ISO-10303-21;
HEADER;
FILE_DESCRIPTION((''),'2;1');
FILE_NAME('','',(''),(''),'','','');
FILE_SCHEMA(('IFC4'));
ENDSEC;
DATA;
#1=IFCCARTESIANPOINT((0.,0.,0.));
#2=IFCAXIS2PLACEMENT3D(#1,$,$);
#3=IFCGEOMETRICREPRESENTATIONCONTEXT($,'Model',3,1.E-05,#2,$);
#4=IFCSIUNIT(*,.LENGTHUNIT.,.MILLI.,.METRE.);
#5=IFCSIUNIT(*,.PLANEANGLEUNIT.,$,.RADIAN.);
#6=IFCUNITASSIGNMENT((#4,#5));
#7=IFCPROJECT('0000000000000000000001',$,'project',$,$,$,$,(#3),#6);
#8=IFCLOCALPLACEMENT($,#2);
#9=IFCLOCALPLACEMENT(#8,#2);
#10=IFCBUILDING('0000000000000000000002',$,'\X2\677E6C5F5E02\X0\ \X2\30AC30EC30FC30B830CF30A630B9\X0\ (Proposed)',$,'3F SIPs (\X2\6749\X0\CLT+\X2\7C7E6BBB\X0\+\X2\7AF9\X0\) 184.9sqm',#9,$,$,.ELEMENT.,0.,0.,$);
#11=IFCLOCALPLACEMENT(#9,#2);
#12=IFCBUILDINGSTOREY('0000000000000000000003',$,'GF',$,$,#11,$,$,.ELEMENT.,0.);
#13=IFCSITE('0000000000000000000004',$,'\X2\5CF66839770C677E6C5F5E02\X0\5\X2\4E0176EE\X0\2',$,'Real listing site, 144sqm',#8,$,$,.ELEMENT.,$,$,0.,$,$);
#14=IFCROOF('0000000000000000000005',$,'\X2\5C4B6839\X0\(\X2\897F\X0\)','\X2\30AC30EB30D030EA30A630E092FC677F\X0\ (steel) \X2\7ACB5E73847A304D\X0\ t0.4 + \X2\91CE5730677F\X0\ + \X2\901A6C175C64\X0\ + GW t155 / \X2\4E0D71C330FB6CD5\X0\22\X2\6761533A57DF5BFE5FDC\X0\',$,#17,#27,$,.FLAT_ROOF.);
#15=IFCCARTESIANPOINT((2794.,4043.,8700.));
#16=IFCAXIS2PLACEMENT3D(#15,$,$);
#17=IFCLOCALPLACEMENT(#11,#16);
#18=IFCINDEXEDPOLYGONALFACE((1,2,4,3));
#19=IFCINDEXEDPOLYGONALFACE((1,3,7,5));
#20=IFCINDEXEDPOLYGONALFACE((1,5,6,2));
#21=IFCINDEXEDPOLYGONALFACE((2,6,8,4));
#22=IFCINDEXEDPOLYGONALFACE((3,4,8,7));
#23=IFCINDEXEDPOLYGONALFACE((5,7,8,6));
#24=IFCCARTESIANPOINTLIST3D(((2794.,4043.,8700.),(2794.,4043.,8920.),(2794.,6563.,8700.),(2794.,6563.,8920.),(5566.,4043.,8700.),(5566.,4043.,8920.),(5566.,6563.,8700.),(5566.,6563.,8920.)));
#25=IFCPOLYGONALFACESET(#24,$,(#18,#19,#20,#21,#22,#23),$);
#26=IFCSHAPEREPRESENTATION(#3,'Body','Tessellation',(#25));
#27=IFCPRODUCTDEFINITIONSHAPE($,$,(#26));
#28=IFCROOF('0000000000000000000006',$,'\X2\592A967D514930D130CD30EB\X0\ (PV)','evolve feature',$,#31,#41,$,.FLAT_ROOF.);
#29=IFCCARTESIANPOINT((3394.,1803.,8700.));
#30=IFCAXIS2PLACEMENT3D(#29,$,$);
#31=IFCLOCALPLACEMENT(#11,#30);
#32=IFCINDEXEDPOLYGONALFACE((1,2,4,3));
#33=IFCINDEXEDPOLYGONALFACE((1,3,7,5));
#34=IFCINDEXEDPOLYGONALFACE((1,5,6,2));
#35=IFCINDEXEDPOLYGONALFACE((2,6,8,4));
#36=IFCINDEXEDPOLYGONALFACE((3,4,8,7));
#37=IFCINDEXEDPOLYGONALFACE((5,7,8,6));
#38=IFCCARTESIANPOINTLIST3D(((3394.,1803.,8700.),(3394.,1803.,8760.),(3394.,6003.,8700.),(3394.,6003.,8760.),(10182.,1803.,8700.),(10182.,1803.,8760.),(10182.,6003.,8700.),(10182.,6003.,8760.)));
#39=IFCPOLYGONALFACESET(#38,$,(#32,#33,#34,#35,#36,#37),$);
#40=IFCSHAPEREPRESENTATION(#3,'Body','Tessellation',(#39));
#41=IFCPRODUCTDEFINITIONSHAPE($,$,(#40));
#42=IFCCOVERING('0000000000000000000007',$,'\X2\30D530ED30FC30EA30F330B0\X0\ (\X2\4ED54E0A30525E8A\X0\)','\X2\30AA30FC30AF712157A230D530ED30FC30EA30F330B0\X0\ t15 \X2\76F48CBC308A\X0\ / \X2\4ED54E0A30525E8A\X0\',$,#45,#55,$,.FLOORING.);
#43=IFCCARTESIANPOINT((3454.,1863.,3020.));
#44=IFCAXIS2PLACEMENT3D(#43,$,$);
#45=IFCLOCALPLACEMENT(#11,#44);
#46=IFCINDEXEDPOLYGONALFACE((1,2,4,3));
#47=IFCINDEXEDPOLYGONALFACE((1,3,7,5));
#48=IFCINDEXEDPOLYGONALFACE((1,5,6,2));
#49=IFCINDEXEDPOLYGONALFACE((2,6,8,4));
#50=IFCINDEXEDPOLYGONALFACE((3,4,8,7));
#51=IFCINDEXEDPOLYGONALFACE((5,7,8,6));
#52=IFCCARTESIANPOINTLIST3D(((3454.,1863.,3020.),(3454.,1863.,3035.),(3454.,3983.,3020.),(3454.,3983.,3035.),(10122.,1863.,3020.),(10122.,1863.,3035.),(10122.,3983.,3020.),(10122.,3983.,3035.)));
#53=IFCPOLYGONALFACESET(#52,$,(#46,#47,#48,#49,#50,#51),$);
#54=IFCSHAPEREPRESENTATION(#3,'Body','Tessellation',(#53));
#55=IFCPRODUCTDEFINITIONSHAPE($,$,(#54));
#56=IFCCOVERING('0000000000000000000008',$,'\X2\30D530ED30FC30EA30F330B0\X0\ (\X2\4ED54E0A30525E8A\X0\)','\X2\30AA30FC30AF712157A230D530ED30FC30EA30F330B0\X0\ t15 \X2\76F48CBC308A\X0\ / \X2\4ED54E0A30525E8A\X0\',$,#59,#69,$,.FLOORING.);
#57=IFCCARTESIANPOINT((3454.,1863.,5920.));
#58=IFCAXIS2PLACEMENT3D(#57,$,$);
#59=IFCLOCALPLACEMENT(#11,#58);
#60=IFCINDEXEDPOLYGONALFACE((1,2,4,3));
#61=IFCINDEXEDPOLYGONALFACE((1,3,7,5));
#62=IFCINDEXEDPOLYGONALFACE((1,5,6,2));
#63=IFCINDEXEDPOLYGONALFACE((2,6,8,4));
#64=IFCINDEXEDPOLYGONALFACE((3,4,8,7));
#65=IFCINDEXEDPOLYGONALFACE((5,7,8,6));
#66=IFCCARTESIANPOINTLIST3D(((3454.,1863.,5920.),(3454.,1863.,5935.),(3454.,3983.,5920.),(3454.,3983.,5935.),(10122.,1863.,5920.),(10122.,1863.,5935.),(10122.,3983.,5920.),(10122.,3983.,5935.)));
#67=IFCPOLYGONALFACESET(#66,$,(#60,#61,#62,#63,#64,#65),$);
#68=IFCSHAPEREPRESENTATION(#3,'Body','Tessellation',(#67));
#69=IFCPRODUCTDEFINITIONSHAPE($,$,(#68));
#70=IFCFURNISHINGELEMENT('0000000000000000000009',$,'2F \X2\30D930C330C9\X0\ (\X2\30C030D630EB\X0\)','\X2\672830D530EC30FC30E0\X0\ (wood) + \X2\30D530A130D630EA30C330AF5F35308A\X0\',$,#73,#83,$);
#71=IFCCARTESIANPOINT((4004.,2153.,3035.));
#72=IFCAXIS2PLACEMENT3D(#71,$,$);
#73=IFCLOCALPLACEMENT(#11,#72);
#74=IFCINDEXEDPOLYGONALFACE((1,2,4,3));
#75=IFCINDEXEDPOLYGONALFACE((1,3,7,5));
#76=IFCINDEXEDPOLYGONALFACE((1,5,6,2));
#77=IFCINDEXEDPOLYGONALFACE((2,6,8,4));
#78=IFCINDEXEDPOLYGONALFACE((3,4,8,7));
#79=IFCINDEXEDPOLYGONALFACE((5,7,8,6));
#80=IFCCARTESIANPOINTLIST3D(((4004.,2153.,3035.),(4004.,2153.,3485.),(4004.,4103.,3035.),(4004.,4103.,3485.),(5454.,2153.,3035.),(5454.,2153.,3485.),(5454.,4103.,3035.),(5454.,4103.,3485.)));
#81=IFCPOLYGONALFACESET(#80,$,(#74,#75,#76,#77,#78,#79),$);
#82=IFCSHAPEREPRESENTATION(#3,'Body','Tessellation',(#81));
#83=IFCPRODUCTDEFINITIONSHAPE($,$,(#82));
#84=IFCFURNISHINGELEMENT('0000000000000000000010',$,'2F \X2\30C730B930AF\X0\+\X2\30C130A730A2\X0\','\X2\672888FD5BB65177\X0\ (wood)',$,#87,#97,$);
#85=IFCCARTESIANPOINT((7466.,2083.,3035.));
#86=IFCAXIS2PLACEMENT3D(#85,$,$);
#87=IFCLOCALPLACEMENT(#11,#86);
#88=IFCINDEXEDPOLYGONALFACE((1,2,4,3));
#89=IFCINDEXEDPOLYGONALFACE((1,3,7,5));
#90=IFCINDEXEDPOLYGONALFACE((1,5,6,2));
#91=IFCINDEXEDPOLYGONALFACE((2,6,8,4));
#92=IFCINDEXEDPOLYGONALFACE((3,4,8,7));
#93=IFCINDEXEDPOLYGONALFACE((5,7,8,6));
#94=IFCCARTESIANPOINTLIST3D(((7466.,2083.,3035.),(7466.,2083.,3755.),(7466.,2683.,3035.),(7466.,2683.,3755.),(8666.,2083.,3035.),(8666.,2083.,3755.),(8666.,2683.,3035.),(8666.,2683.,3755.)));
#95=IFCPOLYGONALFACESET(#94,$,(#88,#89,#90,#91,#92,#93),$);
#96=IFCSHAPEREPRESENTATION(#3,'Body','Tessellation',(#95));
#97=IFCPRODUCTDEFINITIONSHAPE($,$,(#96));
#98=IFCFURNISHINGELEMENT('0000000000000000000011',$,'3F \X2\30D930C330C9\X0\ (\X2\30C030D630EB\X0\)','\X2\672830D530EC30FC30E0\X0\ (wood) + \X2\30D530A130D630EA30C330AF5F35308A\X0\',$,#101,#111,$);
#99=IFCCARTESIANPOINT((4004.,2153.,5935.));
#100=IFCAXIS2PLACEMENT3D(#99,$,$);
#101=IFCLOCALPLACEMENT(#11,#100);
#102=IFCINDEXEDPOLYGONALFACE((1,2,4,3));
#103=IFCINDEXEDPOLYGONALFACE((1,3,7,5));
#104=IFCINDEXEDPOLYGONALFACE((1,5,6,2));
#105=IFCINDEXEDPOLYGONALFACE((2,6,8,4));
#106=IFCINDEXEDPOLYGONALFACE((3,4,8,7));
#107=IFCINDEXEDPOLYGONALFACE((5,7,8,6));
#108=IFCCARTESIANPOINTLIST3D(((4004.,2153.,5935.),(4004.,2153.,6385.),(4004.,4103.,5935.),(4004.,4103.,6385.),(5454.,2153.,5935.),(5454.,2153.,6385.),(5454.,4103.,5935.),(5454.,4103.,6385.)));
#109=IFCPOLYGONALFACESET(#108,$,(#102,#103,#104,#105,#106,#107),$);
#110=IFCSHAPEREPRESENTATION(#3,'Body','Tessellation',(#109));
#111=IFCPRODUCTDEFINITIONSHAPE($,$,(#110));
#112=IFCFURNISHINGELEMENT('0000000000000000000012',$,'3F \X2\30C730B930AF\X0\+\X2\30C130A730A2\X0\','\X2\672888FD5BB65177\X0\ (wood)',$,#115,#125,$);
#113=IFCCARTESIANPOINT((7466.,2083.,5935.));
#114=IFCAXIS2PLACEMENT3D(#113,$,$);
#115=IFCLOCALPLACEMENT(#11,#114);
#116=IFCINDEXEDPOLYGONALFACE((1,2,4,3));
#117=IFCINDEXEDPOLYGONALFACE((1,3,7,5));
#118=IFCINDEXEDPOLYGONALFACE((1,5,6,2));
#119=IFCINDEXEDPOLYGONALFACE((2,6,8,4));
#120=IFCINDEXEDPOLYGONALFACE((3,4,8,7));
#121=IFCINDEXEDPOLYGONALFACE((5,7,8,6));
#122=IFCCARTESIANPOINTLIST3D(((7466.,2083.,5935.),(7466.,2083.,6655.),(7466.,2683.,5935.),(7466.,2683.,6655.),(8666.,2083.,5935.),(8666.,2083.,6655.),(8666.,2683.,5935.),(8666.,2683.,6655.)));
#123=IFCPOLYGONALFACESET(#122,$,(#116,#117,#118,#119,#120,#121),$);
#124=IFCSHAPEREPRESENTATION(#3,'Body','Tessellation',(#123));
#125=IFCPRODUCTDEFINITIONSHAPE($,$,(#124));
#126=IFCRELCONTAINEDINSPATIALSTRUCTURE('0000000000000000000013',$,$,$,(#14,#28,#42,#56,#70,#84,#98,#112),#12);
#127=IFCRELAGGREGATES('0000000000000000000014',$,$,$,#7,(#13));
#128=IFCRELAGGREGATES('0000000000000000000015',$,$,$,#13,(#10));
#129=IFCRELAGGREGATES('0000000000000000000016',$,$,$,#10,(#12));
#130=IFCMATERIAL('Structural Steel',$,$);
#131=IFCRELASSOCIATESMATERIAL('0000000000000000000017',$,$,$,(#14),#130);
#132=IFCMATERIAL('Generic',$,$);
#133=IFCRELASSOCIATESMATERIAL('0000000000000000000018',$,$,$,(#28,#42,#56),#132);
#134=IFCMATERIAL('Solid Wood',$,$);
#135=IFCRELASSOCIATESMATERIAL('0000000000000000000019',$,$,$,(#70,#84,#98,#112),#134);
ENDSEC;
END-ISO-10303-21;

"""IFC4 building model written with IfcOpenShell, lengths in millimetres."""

from ifc_helpers import new_model, si_unit, frame, frame_2d, origin, place, context, project, spatial, rectangle, extrude, material, element, save


model = new_model("IFC4")

# Units and contexts
model_context = context("Model", 3, precision=1e-05, world=origin())
ifc_project = project(units=[si_unit("LENGTHUNIT", "METRE", prefix="MILLI"), si_unit("PLANEANGLEUNIT", "RADIAN")], contexts=[model_context])

# Site, building, storey
site_placement = place(None, origin())
site = spatial("IfcSite", under=ifc_project, at=site_placement, Name="島根県松江市5丁目2", ObjectType="Real listing site, 144sqm", CompositionType="ELEMENT", RefElevation=0.0)
building_placement = place(site_placement, origin())
building = spatial("IfcBuilding", under=site, at=building_placement, Name="松江市 ガレージハウス (Proposed)", ObjectType="3F SIPs (杉CLT+籾殻+竹) 184.9sqm", CompositionType="ELEMENT", ElevationOfRefHeight=0.0, ElevationOfTerrain=0.0)
storey_placement = place(building_placement, origin())
storey = spatial("IfcBuildingStorey", under=building, at=storey_placement, Name="GF", CompositionType="ELEMENT", Elevation=0.0)

# Shared definitions
ifc_material_1 = material(Name="Solid Wood")

# Roofs
ifc_material_2 = material(Name="Structural Steel")
roof_1_placement = place(storey_placement, frame((2794.0, 4043.0, 8700.0)))
element("IfcRoof", 1, at=roof_1_placement, inside=storey, material=ifc_material_2, Name="屋根(西)", Description="ガルバリウム鋼板 (steel) 立平葺き t0.4 + 野地板 + 通気層 + GW t155 / 不燃・法22条区域対応", PredefinedType="FLAT_ROOF", context=model_context, shape_type="SweptSolid", body=[
    extrude(rectangle(XDim=2772.0, YDim=2520.0, at=frame_2d((1386.0, 1260.0))), frame((2794.0, 4043.0, 8700.0)), (0.0, 0.0, 1.0), 220.0),
])
ifc_material_3 = material(Name="Generic")
roof_2_placement = place(storey_placement, frame((3394.0, 1803.0, 8700.0)))
element("IfcRoof", 2, at=roof_2_placement, inside=storey, material=ifc_material_3, Name="太陽光パネル (PV)", Description="evolve feature", PredefinedType="FLAT_ROOF", context=model_context, shape_type="SweptSolid", body=[
    extrude(rectangle(XDim=6788.0, YDim=4200.0, at=frame_2d((3394.0, 2100.0))), frame((3394.0, 1803.0, 8700.0)), (0.0, 0.0, 1.0), 60.0),
])

# Coverings
covering_1_placement = place(storey_placement, frame((3454.0, 1863.0, 3020.0)))
element("IfcCovering", 3, at=covering_1_placement, inside=storey, material=ifc_material_3, Name="フローリング (仕上げ床)", Description="オーク無垢フローリング t15 直貼り / 仕上げ床", PredefinedType="FLOORING", context=model_context, shape_type="SweptSolid", body=[
    extrude(rectangle(XDim=6668.0, YDim=2120.0, at=frame_2d((3334.0, 1060.0))), frame((3454.0, 1863.0, 3020.0)), (0.0, 0.0, 1.0), 15.0),
])
covering_2_placement = place(storey_placement, frame((3454.0, 1863.0, 5920.0)))
element("IfcCovering", 4, at=covering_2_placement, inside=storey, material=ifc_material_3, Name="フローリング (仕上げ床)", Description="オーク無垢フローリング t15 直貼り / 仕上げ床", PredefinedType="FLOORING", context=model_context, shape_type="SweptSolid", body=[
    extrude(rectangle(XDim=6668.0, YDim=2120.0, at=frame_2d((3334.0, 1060.0))), frame((3454.0, 1863.0, 5920.0)), (0.0, 0.0, 1.0), 15.0),
])

# Furnishing elements
furnishing_1_placement = place(storey_placement, frame((4004.0, 2153.0, 3035.0)))
element("IfcFurnishingElement", 5, at=furnishing_1_placement, inside=storey, material=ifc_material_1, Name="2F ベッド (ダブル)", Description="木フレーム (wood) + ファブリック張り", context=model_context, shape_type="SweptSolid", body=[
    extrude(rectangle(XDim=1450.0, YDim=1950.0, at=frame_2d((725.0, 975.0))), frame((4004.0, 2153.0, 3035.0)), (0.0, 0.0, 1.0), 450.0),
])
furnishing_2_placement = place(storey_placement, frame((7466.0, 2083.0, 3035.0)))
element("IfcFurnishingElement", 6, at=furnishing_2_placement, inside=storey, material=ifc_material_1, Name="2F デスク+チェア", Description="木製家具 (wood)", context=model_context, shape_type="SweptSolid", body=[
    extrude(rectangle(XDim=1200.0, YDim=600.0, at=frame_2d((600.0, 300.0))), frame((7466.0, 2083.0, 3035.0)), (0.0, 0.0, 1.0), 720.0),
])
furnishing_3_placement = place(storey_placement, frame((4004.0, 2153.0, 5935.0)))
element("IfcFurnishingElement", 7, at=furnishing_3_placement, inside=storey, material=ifc_material_1, Name="3F ベッド (ダブル)", Description="木フレーム (wood) + ファブリック張り", context=model_context, shape_type="SweptSolid", body=[
    extrude(rectangle(XDim=1450.0, YDim=1950.0, at=frame_2d((725.0, 975.0))), frame((4004.0, 2153.0, 5935.0)), (0.0, 0.0, 1.0), 450.0),
])
furnishing_4_placement = place(storey_placement, frame((7466.0, 2083.0, 5935.0)))
element("IfcFurnishingElement", 8, at=furnishing_4_placement, inside=storey, material=ifc_material_1, Name="3F デスク+チェア", Description="木製家具 (wood)", context=model_context, shape_type="SweptSolid", body=[
    extrude(rectangle(XDim=1200.0, YDim=600.0, at=frame_2d((600.0, 300.0))), frame((7466.0, 2083.0, 5935.0)), (0.0, 0.0, 1.0), 720.0),
])

save(model, "model.ifc")
